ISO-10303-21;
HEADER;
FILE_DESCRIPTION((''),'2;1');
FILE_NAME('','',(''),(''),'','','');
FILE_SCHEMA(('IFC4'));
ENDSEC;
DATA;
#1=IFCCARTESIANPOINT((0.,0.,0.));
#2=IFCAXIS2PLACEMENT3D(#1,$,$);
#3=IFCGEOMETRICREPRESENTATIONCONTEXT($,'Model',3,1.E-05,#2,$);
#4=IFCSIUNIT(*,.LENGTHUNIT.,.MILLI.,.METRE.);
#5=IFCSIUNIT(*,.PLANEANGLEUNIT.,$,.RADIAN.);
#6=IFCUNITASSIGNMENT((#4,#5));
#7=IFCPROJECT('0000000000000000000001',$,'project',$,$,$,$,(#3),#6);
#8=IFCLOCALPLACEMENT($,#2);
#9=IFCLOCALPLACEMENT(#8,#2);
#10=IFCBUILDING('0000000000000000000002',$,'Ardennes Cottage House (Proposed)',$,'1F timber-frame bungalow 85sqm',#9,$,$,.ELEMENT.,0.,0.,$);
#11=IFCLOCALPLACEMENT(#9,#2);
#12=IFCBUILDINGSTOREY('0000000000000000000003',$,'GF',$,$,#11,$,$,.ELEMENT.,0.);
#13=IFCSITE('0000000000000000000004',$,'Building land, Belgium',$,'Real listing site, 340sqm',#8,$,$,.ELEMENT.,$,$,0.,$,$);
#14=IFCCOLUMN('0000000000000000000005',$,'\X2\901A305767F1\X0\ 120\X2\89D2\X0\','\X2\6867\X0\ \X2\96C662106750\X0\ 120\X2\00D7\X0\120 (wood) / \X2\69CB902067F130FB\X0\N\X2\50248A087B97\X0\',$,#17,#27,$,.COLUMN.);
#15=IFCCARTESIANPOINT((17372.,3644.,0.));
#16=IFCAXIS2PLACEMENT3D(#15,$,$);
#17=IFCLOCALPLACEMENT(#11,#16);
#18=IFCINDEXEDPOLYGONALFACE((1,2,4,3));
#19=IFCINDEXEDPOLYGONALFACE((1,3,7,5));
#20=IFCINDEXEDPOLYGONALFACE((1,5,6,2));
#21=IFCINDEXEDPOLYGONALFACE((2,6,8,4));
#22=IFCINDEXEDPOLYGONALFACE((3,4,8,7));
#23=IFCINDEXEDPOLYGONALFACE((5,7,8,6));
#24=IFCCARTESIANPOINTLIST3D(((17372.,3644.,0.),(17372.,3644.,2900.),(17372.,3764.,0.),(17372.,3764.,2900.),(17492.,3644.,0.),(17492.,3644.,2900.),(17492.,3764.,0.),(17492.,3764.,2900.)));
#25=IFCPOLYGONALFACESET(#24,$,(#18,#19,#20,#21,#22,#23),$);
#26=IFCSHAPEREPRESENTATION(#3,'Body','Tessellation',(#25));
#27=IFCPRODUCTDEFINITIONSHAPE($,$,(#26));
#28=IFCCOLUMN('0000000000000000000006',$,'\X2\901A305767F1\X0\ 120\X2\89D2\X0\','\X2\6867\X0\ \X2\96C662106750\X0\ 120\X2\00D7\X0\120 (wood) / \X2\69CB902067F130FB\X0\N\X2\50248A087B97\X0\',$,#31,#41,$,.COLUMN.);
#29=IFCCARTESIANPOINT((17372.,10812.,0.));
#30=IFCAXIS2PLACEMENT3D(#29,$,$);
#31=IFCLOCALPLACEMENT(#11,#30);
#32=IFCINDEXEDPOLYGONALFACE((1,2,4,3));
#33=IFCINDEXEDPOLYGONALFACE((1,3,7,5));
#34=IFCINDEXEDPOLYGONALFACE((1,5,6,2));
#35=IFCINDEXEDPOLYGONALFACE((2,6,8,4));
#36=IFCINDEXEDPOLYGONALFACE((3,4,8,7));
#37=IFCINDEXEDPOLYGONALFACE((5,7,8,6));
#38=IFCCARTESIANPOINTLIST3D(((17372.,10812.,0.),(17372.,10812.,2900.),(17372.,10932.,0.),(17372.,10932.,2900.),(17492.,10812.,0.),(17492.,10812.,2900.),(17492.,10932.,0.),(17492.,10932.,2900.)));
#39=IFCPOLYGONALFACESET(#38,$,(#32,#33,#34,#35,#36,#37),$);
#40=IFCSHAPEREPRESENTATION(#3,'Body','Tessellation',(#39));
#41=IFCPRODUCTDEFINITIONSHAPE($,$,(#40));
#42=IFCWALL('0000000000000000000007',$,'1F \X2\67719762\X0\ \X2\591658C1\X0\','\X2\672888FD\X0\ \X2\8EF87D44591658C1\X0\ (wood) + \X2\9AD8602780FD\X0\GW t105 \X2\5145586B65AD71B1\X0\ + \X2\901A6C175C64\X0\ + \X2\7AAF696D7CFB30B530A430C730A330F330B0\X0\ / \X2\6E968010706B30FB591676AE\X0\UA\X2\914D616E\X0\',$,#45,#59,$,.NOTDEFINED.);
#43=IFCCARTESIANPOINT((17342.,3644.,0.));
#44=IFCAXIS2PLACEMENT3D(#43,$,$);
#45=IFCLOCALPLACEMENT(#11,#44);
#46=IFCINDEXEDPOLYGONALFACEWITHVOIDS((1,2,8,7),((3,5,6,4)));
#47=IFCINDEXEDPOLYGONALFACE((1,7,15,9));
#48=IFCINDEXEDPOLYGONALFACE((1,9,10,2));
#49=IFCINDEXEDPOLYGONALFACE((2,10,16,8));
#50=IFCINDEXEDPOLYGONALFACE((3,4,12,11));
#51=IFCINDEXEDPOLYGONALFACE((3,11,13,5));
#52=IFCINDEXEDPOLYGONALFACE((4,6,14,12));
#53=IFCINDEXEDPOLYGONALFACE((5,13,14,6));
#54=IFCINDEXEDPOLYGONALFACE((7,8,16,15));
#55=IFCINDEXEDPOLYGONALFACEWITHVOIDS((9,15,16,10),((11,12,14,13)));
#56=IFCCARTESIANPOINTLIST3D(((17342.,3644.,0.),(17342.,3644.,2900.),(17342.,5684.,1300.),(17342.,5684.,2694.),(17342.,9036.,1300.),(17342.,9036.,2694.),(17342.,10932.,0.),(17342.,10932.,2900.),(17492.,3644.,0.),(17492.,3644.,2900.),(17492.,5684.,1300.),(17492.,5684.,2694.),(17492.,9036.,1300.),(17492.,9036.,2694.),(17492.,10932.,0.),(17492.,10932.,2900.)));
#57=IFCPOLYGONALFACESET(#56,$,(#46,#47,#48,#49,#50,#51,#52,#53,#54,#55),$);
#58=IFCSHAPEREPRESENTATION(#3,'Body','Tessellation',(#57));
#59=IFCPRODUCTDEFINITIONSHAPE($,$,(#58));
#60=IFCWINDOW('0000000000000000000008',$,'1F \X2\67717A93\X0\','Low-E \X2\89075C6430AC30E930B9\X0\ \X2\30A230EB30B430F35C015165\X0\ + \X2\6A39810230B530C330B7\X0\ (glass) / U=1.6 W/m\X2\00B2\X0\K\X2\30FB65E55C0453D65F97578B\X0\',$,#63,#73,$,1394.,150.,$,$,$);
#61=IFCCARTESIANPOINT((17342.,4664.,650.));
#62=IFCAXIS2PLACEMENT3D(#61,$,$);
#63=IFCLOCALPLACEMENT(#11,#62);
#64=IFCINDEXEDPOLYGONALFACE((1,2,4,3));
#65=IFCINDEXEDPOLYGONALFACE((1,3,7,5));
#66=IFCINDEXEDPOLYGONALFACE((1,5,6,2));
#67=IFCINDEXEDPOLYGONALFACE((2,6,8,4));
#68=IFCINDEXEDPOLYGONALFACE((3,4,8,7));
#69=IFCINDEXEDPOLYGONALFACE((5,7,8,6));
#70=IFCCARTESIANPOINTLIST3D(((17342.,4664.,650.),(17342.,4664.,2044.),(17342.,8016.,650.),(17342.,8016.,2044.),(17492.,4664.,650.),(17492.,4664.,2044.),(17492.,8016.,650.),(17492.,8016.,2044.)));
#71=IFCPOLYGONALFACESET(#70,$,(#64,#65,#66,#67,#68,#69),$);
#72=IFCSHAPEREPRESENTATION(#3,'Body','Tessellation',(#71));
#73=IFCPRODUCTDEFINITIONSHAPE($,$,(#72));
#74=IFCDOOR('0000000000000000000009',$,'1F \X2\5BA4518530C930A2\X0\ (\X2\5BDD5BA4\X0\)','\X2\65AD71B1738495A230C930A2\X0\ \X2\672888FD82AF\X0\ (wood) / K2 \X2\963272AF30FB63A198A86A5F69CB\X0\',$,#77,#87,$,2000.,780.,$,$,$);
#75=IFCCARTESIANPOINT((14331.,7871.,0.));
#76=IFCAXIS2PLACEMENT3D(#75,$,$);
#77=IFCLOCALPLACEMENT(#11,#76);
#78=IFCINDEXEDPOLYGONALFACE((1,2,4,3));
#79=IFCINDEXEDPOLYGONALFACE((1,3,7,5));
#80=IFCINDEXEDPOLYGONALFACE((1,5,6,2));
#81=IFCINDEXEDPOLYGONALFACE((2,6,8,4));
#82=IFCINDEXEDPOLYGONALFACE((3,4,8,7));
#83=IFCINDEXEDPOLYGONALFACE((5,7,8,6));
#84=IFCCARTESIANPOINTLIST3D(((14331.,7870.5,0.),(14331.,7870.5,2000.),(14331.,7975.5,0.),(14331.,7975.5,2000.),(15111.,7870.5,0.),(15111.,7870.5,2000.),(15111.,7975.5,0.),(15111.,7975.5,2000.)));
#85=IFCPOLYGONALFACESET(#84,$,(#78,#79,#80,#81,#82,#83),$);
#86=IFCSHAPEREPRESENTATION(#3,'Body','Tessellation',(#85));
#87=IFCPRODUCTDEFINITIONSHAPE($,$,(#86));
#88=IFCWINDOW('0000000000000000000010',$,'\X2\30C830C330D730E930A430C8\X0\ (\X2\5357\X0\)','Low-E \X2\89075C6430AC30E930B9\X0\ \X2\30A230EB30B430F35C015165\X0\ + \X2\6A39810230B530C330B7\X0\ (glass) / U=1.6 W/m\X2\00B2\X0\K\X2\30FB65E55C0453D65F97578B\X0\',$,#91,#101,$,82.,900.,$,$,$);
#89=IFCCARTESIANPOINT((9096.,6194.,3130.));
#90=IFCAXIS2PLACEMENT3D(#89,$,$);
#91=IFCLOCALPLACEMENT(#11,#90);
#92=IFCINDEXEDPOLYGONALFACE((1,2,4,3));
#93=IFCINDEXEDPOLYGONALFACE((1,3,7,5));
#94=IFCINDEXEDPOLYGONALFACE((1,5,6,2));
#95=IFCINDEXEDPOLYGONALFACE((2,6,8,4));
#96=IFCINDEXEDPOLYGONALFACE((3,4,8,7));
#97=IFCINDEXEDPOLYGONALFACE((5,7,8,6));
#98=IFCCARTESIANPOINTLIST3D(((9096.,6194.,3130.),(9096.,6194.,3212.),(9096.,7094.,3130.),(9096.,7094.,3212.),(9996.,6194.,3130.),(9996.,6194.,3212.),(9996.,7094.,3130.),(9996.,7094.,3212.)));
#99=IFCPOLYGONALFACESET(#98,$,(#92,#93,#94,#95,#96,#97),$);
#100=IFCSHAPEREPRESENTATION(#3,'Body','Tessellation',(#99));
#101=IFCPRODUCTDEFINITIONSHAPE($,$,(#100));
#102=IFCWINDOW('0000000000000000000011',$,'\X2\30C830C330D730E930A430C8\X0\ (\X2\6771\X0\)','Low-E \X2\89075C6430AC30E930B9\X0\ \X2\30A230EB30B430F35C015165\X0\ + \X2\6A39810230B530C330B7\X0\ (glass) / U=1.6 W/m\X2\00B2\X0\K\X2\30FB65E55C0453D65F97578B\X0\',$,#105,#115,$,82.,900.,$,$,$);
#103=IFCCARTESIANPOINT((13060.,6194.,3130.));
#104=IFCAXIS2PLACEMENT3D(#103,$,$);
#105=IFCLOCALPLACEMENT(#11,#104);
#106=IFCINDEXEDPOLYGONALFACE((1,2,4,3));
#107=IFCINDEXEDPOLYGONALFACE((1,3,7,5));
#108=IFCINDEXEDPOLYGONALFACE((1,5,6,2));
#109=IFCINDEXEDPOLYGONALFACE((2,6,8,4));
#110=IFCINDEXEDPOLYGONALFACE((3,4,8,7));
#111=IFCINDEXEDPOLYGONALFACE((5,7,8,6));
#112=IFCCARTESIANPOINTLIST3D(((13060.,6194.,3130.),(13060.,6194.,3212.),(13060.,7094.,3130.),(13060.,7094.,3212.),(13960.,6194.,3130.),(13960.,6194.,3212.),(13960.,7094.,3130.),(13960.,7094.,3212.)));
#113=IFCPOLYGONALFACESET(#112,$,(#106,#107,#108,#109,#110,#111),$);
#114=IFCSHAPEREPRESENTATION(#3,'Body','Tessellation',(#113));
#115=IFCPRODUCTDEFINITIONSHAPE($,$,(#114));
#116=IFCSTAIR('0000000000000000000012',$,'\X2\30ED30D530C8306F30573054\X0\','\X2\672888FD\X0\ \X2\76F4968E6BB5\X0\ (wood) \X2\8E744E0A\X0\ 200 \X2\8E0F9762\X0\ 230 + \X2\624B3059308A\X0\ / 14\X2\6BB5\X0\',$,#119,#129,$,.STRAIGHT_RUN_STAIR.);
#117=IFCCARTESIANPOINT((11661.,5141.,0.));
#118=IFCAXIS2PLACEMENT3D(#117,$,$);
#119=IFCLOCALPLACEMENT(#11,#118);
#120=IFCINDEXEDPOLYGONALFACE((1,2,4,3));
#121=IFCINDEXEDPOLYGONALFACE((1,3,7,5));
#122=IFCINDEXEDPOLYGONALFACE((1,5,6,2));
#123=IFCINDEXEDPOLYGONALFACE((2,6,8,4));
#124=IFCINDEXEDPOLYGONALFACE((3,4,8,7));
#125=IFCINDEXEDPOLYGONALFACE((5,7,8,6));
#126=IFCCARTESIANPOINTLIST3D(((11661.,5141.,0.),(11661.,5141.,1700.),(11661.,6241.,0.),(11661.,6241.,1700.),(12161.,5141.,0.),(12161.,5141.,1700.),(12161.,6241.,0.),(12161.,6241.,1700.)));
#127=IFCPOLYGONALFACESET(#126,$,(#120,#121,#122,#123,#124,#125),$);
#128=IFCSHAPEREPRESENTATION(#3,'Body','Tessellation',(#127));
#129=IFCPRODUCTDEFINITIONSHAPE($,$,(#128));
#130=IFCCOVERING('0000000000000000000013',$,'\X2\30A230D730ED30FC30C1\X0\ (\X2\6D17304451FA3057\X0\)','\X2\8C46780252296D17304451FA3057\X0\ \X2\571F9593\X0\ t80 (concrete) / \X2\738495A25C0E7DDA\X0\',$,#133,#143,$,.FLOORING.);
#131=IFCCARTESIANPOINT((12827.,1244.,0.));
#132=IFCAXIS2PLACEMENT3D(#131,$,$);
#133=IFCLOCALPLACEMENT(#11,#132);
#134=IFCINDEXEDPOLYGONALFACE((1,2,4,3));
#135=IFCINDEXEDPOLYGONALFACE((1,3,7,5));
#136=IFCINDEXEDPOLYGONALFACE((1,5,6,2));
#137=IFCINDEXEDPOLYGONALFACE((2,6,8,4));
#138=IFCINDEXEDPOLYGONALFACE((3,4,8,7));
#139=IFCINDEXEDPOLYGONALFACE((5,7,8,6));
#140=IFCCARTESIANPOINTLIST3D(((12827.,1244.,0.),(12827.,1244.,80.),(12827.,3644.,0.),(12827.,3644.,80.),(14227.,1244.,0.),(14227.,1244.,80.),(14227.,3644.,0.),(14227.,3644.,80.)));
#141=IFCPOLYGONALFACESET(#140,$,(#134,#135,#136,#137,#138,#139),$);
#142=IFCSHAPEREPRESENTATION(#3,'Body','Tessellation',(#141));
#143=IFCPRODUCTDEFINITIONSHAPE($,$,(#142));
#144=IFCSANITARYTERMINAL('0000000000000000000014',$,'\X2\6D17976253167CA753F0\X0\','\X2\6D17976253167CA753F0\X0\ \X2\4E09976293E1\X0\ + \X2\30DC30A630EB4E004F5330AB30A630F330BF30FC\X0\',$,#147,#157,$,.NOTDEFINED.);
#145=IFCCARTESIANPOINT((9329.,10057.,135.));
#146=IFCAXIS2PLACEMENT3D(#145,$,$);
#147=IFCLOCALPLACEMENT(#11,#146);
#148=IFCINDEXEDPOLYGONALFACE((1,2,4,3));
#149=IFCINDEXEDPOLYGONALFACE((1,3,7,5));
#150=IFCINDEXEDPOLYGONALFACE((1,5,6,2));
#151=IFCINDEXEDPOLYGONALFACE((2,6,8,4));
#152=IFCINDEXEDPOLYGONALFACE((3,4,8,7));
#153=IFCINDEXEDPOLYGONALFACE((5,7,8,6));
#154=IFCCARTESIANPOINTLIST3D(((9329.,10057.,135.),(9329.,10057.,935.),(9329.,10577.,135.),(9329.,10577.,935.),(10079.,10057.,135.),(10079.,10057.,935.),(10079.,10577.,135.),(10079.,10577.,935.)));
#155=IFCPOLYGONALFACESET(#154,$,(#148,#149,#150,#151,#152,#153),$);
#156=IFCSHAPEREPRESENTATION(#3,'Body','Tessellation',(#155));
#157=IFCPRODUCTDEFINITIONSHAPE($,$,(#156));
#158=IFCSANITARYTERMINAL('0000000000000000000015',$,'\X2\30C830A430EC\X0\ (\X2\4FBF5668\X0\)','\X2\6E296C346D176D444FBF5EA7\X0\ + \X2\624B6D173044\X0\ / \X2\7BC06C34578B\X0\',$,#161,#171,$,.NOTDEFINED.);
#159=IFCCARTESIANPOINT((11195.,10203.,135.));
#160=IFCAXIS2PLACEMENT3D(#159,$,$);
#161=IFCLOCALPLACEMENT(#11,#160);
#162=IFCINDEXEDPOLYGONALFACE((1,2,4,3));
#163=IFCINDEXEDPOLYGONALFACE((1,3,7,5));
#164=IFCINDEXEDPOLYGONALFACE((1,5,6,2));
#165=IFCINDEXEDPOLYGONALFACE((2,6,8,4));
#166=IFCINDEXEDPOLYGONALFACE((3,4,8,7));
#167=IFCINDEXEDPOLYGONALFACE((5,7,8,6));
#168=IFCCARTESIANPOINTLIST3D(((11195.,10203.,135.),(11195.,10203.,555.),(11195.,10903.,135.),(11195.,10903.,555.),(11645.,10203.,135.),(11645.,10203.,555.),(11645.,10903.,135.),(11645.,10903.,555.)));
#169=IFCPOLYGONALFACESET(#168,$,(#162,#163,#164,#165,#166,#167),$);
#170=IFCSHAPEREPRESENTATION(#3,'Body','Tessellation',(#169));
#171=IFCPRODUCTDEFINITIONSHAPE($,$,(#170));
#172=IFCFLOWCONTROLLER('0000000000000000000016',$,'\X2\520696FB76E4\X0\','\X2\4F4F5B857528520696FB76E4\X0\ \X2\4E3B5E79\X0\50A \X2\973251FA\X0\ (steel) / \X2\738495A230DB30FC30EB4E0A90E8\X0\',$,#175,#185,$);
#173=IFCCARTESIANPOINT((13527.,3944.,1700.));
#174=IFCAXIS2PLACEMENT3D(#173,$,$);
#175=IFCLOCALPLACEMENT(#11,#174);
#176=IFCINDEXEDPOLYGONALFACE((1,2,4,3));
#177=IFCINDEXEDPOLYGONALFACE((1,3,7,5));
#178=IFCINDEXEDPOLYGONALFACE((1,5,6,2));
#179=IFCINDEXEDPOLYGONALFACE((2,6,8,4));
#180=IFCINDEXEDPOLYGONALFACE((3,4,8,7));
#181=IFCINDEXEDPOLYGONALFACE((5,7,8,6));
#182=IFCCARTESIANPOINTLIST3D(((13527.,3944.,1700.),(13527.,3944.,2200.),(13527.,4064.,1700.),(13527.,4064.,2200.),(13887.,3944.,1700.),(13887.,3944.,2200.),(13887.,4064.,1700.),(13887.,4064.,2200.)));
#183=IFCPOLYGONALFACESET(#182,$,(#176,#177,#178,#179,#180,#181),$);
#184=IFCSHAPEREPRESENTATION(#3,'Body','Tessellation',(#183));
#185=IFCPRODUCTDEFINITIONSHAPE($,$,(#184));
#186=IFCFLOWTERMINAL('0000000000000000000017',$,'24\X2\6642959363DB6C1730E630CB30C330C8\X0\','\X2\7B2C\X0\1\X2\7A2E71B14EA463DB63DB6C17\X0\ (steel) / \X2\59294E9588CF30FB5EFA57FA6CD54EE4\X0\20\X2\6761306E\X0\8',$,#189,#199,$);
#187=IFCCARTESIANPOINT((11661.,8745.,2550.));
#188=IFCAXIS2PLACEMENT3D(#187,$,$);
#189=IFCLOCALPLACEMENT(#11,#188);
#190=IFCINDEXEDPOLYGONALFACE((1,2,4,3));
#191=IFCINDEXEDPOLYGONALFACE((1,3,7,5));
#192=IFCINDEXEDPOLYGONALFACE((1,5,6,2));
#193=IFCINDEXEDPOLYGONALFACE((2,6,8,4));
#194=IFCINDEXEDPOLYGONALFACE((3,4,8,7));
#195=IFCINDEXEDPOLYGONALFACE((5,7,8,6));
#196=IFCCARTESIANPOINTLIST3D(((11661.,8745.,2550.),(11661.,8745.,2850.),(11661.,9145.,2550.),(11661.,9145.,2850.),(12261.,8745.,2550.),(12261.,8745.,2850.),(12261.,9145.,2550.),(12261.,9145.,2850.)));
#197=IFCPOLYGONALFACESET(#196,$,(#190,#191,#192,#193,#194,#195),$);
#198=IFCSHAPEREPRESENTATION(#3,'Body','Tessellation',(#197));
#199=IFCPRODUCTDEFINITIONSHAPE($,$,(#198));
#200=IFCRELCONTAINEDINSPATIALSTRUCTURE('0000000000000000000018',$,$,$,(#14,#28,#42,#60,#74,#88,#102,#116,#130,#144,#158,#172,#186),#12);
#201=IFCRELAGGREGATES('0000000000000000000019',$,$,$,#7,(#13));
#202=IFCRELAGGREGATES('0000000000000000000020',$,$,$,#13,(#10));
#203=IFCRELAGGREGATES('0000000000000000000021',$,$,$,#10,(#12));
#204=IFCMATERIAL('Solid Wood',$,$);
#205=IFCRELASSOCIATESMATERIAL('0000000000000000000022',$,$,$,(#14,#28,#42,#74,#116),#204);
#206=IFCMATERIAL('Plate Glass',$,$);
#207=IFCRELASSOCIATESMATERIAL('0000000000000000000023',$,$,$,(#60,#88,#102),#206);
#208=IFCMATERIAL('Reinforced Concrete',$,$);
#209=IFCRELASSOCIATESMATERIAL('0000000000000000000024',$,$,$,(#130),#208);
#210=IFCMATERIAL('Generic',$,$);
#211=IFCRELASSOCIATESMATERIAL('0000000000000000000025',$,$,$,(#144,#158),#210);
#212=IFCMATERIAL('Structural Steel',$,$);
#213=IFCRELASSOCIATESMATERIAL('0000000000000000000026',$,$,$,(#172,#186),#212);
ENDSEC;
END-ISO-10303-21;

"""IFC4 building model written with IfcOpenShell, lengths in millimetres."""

from ifc_helpers import new_model, si_unit, frame, frame_2d, origin, place, context, project, spatial, rectangle, extrude, material, element, fill, save


model = new_model("IFC4")

# Units and contexts
model_context = context("Model", 3, precision=1e-05, world=origin())
ifc_project = project(units=[si_unit("LENGTHUNIT", "METRE", prefix="MILLI"), si_unit("PLANEANGLEUNIT", "RADIAN")], contexts=[model_context])

# Site, building, storey
site_placement = place(None, origin())
site = spatial("IfcSite", under=ifc_project, at=site_placement, Name="Building land, Belgium", ObjectType="Real listing site, 340sqm", CompositionType="ELEMENT", RefElevation=0.0)
building_placement = place(site_placement, origin())
building = spatial("IfcBuilding", under=site, at=building_placement, Name="Ardennes Cottage House (Proposed)", ObjectType="1F timber-frame bungalow 85sqm", CompositionType="ELEMENT", ElevationOfRefHeight=0.0, ElevationOfTerrain=0.0)
storey_placement = place(building_placement, origin())
storey = spatial("IfcBuildingStorey", under=building, at=storey_placement, Name="GF", CompositionType="ELEMENT", Elevation=0.0)

# Columns
ifc_material_1 = material(Name="Solid Wood")
column_1_placement = place(storey_placement, frame((17372.0, 3644.0, 0.0)))
element("IfcColumn", 1, at=column_1_placement, inside=storey, material=ifc_material_1, Name="通し柱 120角", Description="桧 集成材 120×120 (wood) / 構造柱・N値計算", PredefinedType="COLUMN", context=model_context, shape_type="SweptSolid", body=[
    extrude(rectangle(XDim=120.0, YDim=120.0, at=frame_2d((60.0, 60.0))), frame((17372.0, 3644.0, 0.0)), (0.0, 0.0, 1.0), 2900.0),
])
column_2_placement = place(storey_placement, frame((17372.0, 10812.0, 0.0)))
element("IfcColumn", 2, at=column_2_placement, inside=storey, material=ifc_material_1, Name="通し柱 120角", Description="桧 集成材 120×120 (wood) / 構造柱・N値計算", PredefinedType="COLUMN", context=model_context, shape_type="SweptSolid", body=[
    extrude(rectangle(XDim=120.0, YDim=120.0, at=frame_2d((60.0, 60.0))), frame((17372.0, 10812.0, 0.0)), (0.0, 0.0, 1.0), 2900.0),
])

# Wall, opening, window
wall_1_placement = place(storey_placement, frame((17342.0, 3644.0, 0.0)))
wall_1 = element("IfcWall", 3, at=wall_1_placement, inside=storey, material=ifc_material_1, Name="1F 東面 外壁", Description="木製 軸組外壁 (wood) + 高性能GW t105 充填断熱 + 通気層 + 窯業系サイディング / 準耐火・外皮UA配慮", PredefinedType="NOTDEFINED", context=model_context, shape_type="SweptSolid", body=[
    extrude(rectangle(XDim=150.0, YDim=7288.0, at=frame_2d((75.0, 3644.0))), frame((17342.0, 3644.0, 0.0)), (0.0, 0.0, 1.0), 2900.0),
])
opening_placement = place(storey_placement, frame((17342.0, 4664.0, 650.0)))
opening = element("IfcOpeningElement", 4, at=opening_placement, cuts=wall_1, PredefinedType="NOTDEFINED", context=model_context, shape_type="SweptSolid", body=[
    extrude(rectangle(XDim=150.0, YDim=3352.0, at=frame_2d((75.0, 1676.0))), frame((17342.0, 4664.0, 650.0)), (0.0, 0.0, 1.0), 1394.0),
])
ifc_material_2 = material(Name="Plate Glass")
window_1_placement = place(storey_placement, frame((17342.0, 4664.0, 650.0)))
window_1 = element("IfcWindow", 5, at=window_1_placement, inside=storey, material=ifc_material_2, Name="1F 東窓", Description="Low-E 複層ガラス アルゴン封入 + 樹脂サッシ (glass) / U=1.6 W/m²K・日射取得型", OverallHeight=1394.0, OverallWidth=150.0, context=model_context, shape_type="SweptSolid", body=[
    extrude(rectangle(XDim=150.0, YDim=3352.0, at=frame_2d((75.0, 1676.0))), frame((17342.0, 4664.0, 650.0)), (0.0, 0.0, 1.0), 1394.0),
])
fill(opening, window_1)

# Door
door_placement = place(storey_placement, frame((14331.0, 7871.0, 0.0)))
element("IfcDoor", 6, at=door_placement, inside=storey, material=ifc_material_1, Name="1F 室内ドア (寝室)", Description="断熱玄関ドア 木製芯 (wood) / K2 防犯・採風機構", OverallHeight=2000.0, OverallWidth=780.0, context=model_context, shape_type="SweptSolid", body=[
    extrude(rectangle(XDim=780.0, YDim=105.0, at=frame_2d((390.0, 52.0))), frame((14331.0, 7871.0, 0.0)), (0.0, 0.0, 1.0), 2000.0),
])

# Windows
window_2_placement = place(storey_placement, frame((9096.0, 6194.0, 3130.0)))
element("IfcWindow", 7, at=window_2_placement, inside=storey, material=ifc_material_2, Name="トップライト (南)", Description="Low-E 複層ガラス アルゴン封入 + 樹脂サッシ (glass) / U=1.6 W/m²K・日射取得型", OverallHeight=82.0, OverallWidth=900.0, context=model_context, shape_type="SweptSolid", body=[
    extrude(rectangle(XDim=900.0, YDim=900.0, at=frame_2d((450.0, 450.0))), frame((9096.0, 6194.0, 3130.0)), (0.0, 0.0, 1.0), 82.0),
])
window_3_placement = place(storey_placement, frame((13060.0, 6194.0, 3130.0)))
element("IfcWindow", 8, at=window_3_placement, inside=storey, material=ifc_material_2, Name="トップライト (東)", Description="Low-E 複層ガラス アルゴン封入 + 樹脂サッシ (glass) / U=1.6 W/m²K・日射取得型", OverallHeight=82.0, OverallWidth=900.0, context=model_context, shape_type="SweptSolid", body=[
    extrude(rectangle(XDim=900.0, YDim=900.0, at=frame_2d((450.0, 450.0))), frame((13060.0, 6194.0, 3130.0)), (0.0, 0.0, 1.0), 82.0),
])

# Stair
stair_placement = place(storey_placement, frame((11661.0, 5141.0, 0.0)))
element("IfcStair", 9, at=stair_placement, inside=storey, material=ifc_material_1, Name="ロフトはしご", Description="木製 直階段 (wood) 蹴上 200 踏面 230 + 手すり / 14段", PredefinedType="STRAIGHT_RUN_STAIR", context=model_context, shape_type="SweptSolid", body=[
    extrude(rectangle(XDim=500.0, YDim=1100.0, at=frame_2d((250.0, 550.0))), frame((11661.0, 5141.0, 0.0)), (0.0, 0.0, 1.0), 1700.0),
])

# Covering
ifc_material_3 = material(Name="Reinforced Concrete")
covering_placement = place(storey_placement, frame((12827.0, 1244.0, 0.0)))
element("IfcCovering", 10, at=covering_placement, inside=storey, material=ifc_material_3, Name="アプローチ (洗い出し)", Description="豆砂利洗い出し 土間 t80 (concrete) / 玄関導線", PredefinedType="FLOORING", context=model_context, shape_type="SweptSolid", body=[
    extrude(rectangle(XDim=1400.0, YDim=2400.0, at=frame_2d((700.0, 1200.0))), frame((12827.0, 1244.0, 0.0)), (0.0, 0.0, 1.0), 80.0),
])

# Sanitary terminals
ifc_material_4 = material(Name="Generic")
sanitary_terminal_1_placement = place(storey_placement, frame((9329.0, 10057.0, 135.0)))
element("IfcSanitaryTerminal", 11, at=sanitary_terminal_1_placement, inside=storey, material=ifc_material_4, Name="洗面化粧台", Description="洗面化粧台 三面鏡 + ボウル一体カウンター", PredefinedType="NOTDEFINED", context=model_context, shape_type="SweptSolid", body=[
    extrude(rectangle(XDim=750.0, YDim=520.0, at=frame_2d((375.0, 260.0))), frame((9329.0, 10057.0, 135.0)), (0.0, 0.0, 1.0), 800.0),
])
sanitary_terminal_2_placement = place(storey_placement, frame((11195.0, 10203.0, 135.0)))
element("IfcSanitaryTerminal", 12, at=sanitary_terminal_2_placement, inside=storey, material=ifc_material_4, Name="トイレ (便器)", Description="温水洗浄便座 + 手洗い / 節水型", PredefinedType="NOTDEFINED", context=model_context, shape_type="SweptSolid", body=[
    extrude(rectangle(XDim=450.0, YDim=700.0, at=frame_2d((225.0, 350.0))), frame((11195.0, 10203.0, 135.0)), (0.0, 0.0, 1.0), 420.0),
])

# Flow controller
ifc_material_5 = material(Name="Structural Steel")
flow_controller_placement = place(storey_placement, frame((13527.0, 3944.0, 1700.0)))
element("IfcFlowController", 13, at=flow_controller_placement, inside=storey, material=ifc_material_5, Name="分電盤", Description="住宅用分電盤 主幹50A 露出 (steel) / 玄関ホール上部", context=model_context, shape_type="SweptSolid", body=[
    extrude(rectangle(XDim=360.0, YDim=120.0, at=frame_2d((180.0, 60.0))), frame((13527.0, 3944.0, 1700.0)), (0.0, 0.0, 1.0), 500.0),
])

# Flow terminal
flow_terminal_1_placement = place(storey_placement, frame((11661.0, 8745.0, 2550.0)))
element("IfcFlowTerminal", 14, at=flow_terminal_1_placement, inside=storey, material=ifc_material_5, Name="24時間換気ユニット", Description="第1種熱交換換気 (steel) / 天井裏・建基法令20条の8", context=model_context, shape_type="SweptSolid", body=[
    extrude(rectangle(XDim=600.0, YDim=400.0, at=frame_2d((300.0, 200.0))), frame((11661.0, 8745.0, 2550.0)), (0.0, 0.0, 1.0), 300.0),
])

save(model, "model.ifc")
